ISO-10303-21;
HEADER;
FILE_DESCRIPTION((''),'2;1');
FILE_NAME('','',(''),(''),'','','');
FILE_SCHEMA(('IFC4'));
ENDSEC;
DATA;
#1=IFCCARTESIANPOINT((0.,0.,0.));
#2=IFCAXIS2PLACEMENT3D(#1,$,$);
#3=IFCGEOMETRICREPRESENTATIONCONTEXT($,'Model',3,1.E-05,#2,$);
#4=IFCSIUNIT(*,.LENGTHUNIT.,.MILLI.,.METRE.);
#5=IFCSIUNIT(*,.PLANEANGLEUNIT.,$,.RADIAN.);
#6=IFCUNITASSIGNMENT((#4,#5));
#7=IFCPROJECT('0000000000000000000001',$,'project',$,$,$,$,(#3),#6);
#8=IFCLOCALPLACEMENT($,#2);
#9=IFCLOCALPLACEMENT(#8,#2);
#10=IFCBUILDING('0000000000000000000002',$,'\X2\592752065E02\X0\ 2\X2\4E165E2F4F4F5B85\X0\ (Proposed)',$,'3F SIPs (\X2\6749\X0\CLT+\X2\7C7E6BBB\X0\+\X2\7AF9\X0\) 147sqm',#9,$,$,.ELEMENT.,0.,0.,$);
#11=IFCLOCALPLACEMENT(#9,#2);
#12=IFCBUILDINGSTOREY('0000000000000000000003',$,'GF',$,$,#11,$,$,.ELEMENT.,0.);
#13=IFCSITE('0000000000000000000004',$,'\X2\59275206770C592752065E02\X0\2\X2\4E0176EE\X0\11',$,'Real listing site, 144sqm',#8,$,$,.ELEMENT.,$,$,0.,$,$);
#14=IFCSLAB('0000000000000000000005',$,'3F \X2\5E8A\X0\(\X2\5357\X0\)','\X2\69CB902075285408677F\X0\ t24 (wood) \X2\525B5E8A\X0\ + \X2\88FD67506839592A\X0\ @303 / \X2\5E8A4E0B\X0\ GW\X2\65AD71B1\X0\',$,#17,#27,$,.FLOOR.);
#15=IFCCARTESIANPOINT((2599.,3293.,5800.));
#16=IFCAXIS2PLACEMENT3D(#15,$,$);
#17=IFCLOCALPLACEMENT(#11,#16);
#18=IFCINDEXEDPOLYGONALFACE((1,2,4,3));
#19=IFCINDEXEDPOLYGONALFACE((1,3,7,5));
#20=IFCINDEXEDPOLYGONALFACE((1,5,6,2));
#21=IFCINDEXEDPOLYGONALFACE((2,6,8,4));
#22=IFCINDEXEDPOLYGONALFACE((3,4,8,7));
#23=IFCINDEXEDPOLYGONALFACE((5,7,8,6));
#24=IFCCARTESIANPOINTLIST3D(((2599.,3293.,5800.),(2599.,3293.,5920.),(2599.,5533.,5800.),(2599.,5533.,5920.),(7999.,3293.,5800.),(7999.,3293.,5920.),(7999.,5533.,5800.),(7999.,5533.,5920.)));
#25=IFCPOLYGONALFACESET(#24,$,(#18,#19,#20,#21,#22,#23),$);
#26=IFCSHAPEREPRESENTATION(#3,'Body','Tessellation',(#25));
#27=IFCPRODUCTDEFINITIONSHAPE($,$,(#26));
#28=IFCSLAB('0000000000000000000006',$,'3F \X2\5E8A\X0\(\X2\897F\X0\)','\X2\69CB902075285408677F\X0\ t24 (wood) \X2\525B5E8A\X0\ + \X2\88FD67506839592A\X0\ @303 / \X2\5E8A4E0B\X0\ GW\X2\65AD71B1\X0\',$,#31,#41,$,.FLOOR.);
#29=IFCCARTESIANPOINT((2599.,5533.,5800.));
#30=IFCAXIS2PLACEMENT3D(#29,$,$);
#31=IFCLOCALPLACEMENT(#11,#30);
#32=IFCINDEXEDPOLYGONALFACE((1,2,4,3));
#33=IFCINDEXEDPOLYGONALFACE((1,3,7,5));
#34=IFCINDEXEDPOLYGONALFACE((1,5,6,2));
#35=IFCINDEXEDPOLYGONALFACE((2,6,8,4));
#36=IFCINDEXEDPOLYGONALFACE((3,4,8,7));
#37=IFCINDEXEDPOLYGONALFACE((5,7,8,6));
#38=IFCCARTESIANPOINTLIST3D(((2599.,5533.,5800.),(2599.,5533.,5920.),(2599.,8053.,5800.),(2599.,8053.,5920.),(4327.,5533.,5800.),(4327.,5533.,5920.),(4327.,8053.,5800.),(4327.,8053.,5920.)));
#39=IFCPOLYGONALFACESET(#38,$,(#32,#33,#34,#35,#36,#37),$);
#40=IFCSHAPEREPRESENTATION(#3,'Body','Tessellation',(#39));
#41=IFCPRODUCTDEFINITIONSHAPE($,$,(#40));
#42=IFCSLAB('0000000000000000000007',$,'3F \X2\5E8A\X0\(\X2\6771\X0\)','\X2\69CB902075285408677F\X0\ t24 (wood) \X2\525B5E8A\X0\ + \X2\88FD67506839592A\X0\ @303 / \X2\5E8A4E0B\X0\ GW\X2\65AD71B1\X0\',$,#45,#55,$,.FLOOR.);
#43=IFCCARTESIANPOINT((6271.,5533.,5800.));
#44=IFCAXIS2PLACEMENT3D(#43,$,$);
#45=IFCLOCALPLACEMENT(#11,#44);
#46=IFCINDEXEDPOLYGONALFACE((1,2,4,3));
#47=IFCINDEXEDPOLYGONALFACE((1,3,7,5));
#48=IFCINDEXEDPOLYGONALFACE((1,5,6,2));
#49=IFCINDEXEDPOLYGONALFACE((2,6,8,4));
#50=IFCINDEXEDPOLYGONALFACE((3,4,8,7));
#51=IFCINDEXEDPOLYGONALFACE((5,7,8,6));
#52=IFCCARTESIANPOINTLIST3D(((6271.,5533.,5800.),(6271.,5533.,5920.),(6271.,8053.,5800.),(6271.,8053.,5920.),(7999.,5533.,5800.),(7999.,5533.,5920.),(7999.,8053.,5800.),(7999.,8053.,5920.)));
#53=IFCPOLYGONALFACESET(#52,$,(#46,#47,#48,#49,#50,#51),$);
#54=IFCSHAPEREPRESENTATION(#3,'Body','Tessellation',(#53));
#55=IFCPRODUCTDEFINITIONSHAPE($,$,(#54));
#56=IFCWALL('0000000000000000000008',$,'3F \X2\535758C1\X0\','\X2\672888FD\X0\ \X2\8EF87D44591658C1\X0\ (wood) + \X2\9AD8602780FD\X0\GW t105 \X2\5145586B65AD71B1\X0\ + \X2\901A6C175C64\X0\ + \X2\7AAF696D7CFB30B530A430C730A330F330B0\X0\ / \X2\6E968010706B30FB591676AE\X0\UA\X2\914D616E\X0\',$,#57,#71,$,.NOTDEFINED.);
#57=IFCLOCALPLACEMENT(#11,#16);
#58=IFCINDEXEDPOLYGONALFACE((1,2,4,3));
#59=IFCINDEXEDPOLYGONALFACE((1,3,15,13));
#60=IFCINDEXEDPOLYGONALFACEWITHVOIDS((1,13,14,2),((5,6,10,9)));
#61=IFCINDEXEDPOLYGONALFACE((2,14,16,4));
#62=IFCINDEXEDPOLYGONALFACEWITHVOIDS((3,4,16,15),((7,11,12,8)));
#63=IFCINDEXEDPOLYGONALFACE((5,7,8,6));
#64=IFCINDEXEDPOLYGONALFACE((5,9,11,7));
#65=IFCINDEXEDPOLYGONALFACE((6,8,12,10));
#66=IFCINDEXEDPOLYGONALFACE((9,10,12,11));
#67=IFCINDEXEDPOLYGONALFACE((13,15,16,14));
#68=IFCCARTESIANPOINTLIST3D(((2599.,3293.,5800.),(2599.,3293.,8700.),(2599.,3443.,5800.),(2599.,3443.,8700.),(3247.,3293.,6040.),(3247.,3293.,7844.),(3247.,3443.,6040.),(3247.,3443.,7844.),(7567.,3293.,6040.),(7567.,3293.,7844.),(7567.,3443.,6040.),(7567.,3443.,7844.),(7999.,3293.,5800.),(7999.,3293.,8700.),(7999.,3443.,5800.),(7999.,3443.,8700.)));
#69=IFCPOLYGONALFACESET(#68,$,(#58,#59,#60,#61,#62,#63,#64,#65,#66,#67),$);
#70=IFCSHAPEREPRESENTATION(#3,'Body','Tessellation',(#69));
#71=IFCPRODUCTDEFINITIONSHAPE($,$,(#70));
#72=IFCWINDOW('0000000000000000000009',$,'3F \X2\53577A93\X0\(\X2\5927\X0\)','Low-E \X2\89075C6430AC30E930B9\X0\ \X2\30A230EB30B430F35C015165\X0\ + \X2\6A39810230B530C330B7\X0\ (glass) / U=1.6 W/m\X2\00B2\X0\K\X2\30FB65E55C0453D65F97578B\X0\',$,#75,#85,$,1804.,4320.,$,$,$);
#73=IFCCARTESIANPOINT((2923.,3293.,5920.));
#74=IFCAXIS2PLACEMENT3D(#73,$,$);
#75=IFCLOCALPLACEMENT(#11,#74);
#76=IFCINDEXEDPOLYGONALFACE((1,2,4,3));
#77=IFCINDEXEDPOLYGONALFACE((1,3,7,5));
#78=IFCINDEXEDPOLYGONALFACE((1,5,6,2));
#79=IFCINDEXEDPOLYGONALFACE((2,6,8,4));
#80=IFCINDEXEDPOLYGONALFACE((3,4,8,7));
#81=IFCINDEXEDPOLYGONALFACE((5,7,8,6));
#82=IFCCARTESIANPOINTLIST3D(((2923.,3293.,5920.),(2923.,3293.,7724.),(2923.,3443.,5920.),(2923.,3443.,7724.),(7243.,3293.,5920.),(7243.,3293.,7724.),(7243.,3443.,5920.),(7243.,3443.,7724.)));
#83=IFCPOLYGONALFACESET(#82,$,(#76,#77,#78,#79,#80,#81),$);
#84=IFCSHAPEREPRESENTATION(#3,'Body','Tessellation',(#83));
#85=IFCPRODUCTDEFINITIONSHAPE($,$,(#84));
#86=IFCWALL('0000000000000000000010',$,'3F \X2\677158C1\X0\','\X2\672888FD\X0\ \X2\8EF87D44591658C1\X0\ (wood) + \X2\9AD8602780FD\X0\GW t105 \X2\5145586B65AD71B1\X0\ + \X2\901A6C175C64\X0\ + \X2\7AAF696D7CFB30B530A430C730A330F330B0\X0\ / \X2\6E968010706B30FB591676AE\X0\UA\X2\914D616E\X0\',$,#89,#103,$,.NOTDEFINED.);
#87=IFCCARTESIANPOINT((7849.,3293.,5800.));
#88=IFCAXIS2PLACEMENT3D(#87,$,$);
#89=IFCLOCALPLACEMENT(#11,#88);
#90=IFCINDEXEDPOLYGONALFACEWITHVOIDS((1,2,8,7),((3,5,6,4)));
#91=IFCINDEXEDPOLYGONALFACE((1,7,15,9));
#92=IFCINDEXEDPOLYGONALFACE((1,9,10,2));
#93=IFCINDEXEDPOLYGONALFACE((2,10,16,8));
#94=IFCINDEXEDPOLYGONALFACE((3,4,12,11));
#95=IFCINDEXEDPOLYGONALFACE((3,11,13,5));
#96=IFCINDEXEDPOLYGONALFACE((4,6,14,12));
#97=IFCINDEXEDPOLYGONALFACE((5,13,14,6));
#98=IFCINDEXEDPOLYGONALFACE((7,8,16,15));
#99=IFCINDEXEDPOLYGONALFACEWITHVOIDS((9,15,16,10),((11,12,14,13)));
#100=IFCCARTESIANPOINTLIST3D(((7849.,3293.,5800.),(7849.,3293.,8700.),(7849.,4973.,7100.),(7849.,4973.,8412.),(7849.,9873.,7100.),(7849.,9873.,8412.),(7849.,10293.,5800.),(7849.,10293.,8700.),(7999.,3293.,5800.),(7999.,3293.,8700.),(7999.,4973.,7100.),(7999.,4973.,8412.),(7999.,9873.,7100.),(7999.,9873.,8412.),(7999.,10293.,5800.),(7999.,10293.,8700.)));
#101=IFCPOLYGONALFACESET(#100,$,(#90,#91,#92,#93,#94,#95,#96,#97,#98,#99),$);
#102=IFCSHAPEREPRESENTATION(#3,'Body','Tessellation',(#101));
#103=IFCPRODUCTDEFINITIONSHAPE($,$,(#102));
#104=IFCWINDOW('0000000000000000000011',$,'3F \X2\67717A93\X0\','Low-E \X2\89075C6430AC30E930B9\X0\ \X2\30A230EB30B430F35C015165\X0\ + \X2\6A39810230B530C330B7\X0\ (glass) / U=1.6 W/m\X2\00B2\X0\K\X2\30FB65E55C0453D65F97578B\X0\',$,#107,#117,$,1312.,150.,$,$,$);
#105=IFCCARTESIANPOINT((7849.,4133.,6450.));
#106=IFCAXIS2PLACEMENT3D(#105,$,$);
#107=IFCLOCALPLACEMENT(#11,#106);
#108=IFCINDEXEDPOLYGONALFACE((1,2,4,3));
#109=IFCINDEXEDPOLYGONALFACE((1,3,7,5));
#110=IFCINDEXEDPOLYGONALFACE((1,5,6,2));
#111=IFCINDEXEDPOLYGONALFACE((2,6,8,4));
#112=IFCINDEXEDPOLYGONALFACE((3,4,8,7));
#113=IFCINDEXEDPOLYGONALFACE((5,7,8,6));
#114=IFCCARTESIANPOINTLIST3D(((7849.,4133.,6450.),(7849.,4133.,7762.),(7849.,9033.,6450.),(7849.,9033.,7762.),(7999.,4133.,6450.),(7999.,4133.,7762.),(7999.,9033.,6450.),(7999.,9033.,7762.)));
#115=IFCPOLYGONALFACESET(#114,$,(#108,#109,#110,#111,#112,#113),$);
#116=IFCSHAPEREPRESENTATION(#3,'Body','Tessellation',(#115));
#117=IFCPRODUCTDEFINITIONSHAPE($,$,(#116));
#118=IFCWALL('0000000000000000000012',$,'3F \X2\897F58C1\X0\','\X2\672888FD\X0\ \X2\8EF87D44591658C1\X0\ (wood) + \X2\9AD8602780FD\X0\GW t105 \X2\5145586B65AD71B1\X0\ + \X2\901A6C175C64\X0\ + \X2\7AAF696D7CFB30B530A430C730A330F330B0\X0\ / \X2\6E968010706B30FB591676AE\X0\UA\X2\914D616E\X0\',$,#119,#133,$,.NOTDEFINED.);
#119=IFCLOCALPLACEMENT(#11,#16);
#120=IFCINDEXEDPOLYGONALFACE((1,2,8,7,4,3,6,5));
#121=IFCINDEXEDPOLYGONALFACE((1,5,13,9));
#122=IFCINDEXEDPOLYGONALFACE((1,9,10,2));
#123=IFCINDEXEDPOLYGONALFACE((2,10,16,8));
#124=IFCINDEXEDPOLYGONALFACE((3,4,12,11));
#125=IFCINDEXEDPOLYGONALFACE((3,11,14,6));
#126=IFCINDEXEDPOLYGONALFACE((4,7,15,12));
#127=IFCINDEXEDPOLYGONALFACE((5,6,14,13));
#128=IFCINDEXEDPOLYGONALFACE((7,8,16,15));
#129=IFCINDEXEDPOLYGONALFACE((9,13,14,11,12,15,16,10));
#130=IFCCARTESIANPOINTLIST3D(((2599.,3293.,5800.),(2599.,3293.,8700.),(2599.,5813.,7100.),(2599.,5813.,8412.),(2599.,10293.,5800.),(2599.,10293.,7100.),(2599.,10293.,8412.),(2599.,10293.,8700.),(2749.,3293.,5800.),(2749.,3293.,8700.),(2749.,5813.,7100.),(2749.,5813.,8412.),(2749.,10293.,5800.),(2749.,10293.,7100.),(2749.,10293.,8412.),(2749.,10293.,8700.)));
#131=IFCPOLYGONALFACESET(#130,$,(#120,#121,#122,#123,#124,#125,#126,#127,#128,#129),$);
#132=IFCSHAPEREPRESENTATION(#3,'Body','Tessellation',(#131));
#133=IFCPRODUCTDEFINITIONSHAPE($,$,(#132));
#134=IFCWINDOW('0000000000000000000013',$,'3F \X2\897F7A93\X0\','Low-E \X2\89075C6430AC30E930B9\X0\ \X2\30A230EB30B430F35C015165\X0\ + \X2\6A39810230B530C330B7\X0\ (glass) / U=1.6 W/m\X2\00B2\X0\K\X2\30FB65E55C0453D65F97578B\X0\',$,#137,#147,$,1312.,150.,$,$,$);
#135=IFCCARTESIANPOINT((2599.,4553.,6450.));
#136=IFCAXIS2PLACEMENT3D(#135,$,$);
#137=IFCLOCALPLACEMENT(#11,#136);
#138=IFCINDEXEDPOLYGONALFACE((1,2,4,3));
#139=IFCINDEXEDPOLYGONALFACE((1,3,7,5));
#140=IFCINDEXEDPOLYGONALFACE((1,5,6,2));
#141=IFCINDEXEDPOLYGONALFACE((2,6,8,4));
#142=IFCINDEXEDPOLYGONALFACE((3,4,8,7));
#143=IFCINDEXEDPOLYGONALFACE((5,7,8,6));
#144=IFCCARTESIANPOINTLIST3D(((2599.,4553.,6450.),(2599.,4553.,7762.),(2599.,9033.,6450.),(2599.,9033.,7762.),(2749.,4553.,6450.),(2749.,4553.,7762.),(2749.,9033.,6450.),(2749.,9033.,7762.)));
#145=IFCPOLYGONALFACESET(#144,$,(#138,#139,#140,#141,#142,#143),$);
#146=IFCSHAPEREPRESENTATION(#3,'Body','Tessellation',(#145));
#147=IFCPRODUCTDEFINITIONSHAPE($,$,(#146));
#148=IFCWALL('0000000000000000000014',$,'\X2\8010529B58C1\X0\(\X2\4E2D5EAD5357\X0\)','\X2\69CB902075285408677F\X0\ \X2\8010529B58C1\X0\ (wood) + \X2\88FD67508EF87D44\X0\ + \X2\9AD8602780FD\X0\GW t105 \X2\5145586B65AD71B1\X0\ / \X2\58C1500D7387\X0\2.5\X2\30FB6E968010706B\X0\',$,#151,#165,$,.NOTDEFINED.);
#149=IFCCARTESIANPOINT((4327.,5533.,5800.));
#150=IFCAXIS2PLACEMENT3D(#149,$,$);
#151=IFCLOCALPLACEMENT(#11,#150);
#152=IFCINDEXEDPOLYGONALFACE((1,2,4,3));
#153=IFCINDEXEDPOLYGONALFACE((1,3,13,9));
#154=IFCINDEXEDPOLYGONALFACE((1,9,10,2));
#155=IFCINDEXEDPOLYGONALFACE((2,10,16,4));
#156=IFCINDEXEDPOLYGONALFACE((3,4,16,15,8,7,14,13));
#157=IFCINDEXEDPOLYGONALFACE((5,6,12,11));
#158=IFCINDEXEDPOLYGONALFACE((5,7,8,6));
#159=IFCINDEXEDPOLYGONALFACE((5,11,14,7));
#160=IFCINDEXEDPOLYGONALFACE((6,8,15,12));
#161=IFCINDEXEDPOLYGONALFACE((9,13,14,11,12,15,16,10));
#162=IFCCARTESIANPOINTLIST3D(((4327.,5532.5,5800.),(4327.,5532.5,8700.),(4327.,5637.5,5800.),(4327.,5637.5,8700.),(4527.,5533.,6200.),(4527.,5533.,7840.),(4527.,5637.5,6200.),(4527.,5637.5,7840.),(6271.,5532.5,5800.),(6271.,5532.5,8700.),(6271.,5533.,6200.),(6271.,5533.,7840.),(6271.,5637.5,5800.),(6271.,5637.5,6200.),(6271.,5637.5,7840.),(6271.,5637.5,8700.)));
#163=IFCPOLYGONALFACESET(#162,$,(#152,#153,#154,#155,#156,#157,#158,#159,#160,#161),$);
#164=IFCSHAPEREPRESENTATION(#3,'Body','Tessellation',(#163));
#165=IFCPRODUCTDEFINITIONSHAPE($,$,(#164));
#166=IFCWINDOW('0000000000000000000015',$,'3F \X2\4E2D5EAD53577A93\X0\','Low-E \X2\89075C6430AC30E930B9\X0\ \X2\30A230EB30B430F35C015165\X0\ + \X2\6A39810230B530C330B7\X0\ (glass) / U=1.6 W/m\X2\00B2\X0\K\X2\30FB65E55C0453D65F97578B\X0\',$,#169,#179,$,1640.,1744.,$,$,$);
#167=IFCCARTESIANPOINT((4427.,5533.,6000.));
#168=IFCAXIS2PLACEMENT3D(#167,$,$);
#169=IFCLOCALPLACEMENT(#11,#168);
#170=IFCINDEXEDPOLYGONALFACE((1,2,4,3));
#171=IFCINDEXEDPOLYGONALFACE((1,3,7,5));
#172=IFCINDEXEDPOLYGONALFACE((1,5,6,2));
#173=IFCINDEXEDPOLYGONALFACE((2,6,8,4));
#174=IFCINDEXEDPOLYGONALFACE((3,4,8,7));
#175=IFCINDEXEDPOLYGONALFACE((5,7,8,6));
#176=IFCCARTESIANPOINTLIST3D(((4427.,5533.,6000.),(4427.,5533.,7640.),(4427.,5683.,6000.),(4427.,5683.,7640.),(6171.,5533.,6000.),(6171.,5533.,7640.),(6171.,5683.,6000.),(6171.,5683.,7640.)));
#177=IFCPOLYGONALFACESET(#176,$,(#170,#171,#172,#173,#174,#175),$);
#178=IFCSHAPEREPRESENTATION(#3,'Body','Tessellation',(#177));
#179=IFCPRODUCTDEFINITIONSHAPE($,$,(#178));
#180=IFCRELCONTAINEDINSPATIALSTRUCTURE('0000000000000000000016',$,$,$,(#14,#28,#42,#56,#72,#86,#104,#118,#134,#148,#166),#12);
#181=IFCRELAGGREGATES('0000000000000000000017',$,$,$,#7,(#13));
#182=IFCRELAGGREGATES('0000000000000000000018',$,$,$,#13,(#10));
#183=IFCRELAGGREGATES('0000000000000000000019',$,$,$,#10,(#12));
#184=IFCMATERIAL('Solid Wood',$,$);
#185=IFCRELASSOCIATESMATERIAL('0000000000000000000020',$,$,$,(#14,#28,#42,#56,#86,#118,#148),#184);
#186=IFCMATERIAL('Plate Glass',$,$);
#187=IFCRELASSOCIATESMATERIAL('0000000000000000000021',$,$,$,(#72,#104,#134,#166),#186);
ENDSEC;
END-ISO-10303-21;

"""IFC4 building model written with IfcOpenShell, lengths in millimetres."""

from ifc_helpers import new_model, si_unit, frame, frame_2d, origin, place, context, project, spatial, rectangle, extrude, material, element, fill, save


model = new_model("IFC4")

# Units and contexts
model_context = context("Model", 3, precision=1e-05, world=origin())
ifc_project = project(units=[si_unit("LENGTHUNIT", "METRE", prefix="MILLI"), si_unit("PLANEANGLEUNIT", "RADIAN")], contexts=[model_context])

# Site, building, storey
site_placement = place(None, origin())
site = spatial("IfcSite", under=ifc_project, at=site_placement, Name="大分県大分市2丁目11", ObjectType="Real listing site, 144sqm", CompositionType="ELEMENT", RefElevation=0.0)
building_placement = place(site_placement, origin())
building = spatial("IfcBuilding", under=site, at=building_placement, Name="大分市 2世帯住宅 (Proposed)", ObjectType="3F SIPs (杉CLT+籾殻+竹) 147sqm", CompositionType="ELEMENT", ElevationOfRefHeight=0.0, ElevationOfTerrain=0.0)
storey_placement = place(building_placement, origin())
storey = spatial("IfcBuildingStorey", under=building, at=storey_placement, Name="GF", CompositionType="ELEMENT", Elevation=0.0)

# Slabs
ifc_material_1 = material(Name="Solid Wood")
slab_1_placement = place(storey_placement, frame((2599.0, 3293.0, 5800.0)))
element("IfcSlab", 1, at=slab_1_placement, inside=storey, material=ifc_material_1, Name="3F 床(南)", Description="構造用合板 t24 (wood) 剛床 + 製材根太 @303 / 床下 GW断熱", PredefinedType="FLOOR", context=model_context, shape_type="SweptSolid", body=[
    extrude(rectangle(XDim=5400.0, YDim=2240.0, at=frame_2d((2700.0, 1120.0))), frame((2599.0, 3293.0, 5800.0)), (0.0, 0.0, 1.0), 120.0),
])
slab_2_placement = place(storey_placement, frame((2599.0, 5533.0, 5800.0)))
element("IfcSlab", 2, at=slab_2_placement, inside=storey, material=ifc_material_1, Name="3F 床(西)", Description="構造用合板 t24 (wood) 剛床 + 製材根太 @303 / 床下 GW断熱", PredefinedType="FLOOR", context=model_context, shape_type="SweptSolid", body=[
    extrude(rectangle(XDim=1728.0, YDim=2520.0, at=frame_2d((864.0, 1260.0))), frame((2599.0, 5533.0, 5800.0)), (0.0, 0.0, 1.0), 120.0),
])
slab_3_placement = place(storey_placement, frame((6271.0, 5533.0, 5800.0)))
element("IfcSlab", 3, at=slab_3_placement, inside=storey, material=ifc_material_1, Name="3F 床(東)", Description="構造用合板 t24 (wood) 剛床 + 製材根太 @303 / 床下 GW断熱", PredefinedType="FLOOR", context=model_context, shape_type="SweptSolid", body=[
    extrude(rectangle(XDim=1728.0, YDim=2520.0, at=frame_2d((864.0, 1260.0))), frame((6271.0, 5533.0, 5800.0)), (0.0, 0.0, 1.0), 120.0),
])

# Walls, openings, windows
wall_1_placement = place(storey_placement, frame((2599.0, 3293.0, 5800.0)))
wall_1 = element("IfcWall", 4, at=wall_1_placement, inside=storey, material=ifc_material_1, Name="3F 南壁", Description="木製 軸組外壁 (wood) + 高性能GW t105 充填断熱 + 通気層 + 窯業系サイディング / 準耐火・外皮UA配慮", PredefinedType="NOTDEFINED", context=model_context, shape_type="SweptSolid", body=[
    extrude(rectangle(XDim=5400.0, YDim=150.0, at=frame_2d((2700.0, 75.0))), frame((2599.0, 3293.0, 5800.0)), (0.0, 0.0, 1.0), 2900.0),
])
opening_1_placement = place(storey_placement, frame((2923.0, 3293.0, 5920.0)))
opening_1 = element("IfcOpeningElement", 5, at=opening_1_placement, cuts=wall_1, PredefinedType="NOTDEFINED", context=model_context, shape_type="SweptSolid", body=[
    extrude(rectangle(XDim=4320.0, YDim=150.0, at=frame_2d((2160.0, 75.0))), frame((2923.0, 3293.0, 5920.0)), (0.0, 0.0, 1.0), 1804.0),
])
ifc_material_2 = material(Name="Plate Glass")
window_1_placement = place(storey_placement, frame((2923.0, 3293.0, 5920.0)))
window_1 = element("IfcWindow", 6, at=window_1_placement, inside=storey, material=ifc_material_2, Name="3F 南窓(大)", Description="Low-E 複層ガラス アルゴン封入 + 樹脂サッシ (glass) / U=1.6 W/m²K・日射取得型", OverallHeight=1804.0, OverallWidth=4320.0, context=model_context, shape_type="SweptSolid", body=[
    extrude(rectangle(XDim=4320.0, YDim=150.0, at=frame_2d((2160.0, 75.0))), frame((2923.0, 3293.0, 5920.0)), (0.0, 0.0, 1.0), 1804.0),
])
fill(opening_1, window_1)
wall_2_placement = place(storey_placement, frame((7849.0, 3293.0, 5800.0)))
wall_2 = element("IfcWall", 7, at=wall_2_placement, inside=storey, material=ifc_material_1, Name="3F 東壁", Description="木製 軸組外壁 (wood) + 高性能GW t105 充填断熱 + 通気層 + 窯業系サイディング / 準耐火・外皮UA配慮", PredefinedType="NOTDEFINED", context=model_context, shape_type="SweptSolid", body=[
    extrude(rectangle(XDim=150.0, YDim=7000.0, at=frame_2d((75.0, 3500.0))), frame((7849.0, 3293.0, 5800.0)), (0.0, 0.0, 1.0), 2900.0),
])
opening_2_placement = place(storey_placement, frame((7849.0, 4133.0, 6450.0)))
opening_2 = element("IfcOpeningElement", 8, at=opening_2_placement, cuts=wall_2, PredefinedType="NOTDEFINED", context=model_context, shape_type="SweptSolid", body=[
    extrude(rectangle(XDim=150.0, YDim=4900.0, at=frame_2d((75.0, 2450.0))), frame((7849.0, 4133.0, 6450.0)), (0.0, 0.0, 1.0), 1312.0),
])
window_2_placement = place(storey_placement, frame((7849.0, 4133.0, 6450.0)))
window_2 = element("IfcWindow", 9, at=window_2_placement, inside=storey, material=ifc_material_2, Name="3F 東窓", Description="Low-E 複層ガラス アルゴン封入 + 樹脂サッシ (glass) / U=1.6 W/m²K・日射取得型", OverallHeight=1312.0, OverallWidth=150.0, context=model_context, shape_type="SweptSolid", body=[
    extrude(rectangle(XDim=150.0, YDim=4900.0, at=frame_2d((75.0, 2450.0))), frame((7849.0, 4133.0, 6450.0)), (0.0, 0.0, 1.0), 1312.0),
])
fill(opening_2, window_2)
wall_3_placement = place(storey_placement, frame((2599.0, 3293.0, 5800.0)))
wall_3 = element("IfcWall", 10, at=wall_3_placement, inside=storey, material=ifc_material_1, Name="3F 西壁", Description="木製 軸組外壁 (wood) + 高性能GW t105 充填断熱 + 通気層 + 窯業系サイディング / 準耐火・外皮UA配慮", PredefinedType="NOTDEFINED", context=model_context, shape_type="SweptSolid", body=[
    extrude(rectangle(XDim=150.0, YDim=7000.0, at=frame_2d((75.0, 3500.0))), frame((2599.0, 3293.0, 5800.0)), (0.0, 0.0, 1.0), 2900.0),
])
opening_3_placement = place(storey_placement, frame((2599.0, 4553.0, 6450.0)))
opening_3 = element("IfcOpeningElement", 11, at=opening_3_placement, cuts=wall_3, PredefinedType="NOTDEFINED", context=model_context, shape_type="SweptSolid", body=[
    extrude(rectangle(XDim=150.0, YDim=4480.0, at=frame_2d((75.0, 2240.0))), frame((2599.0, 4553.0, 6450.0)), (0.0, 0.0, 1.0), 1312.0),
])
window_3_placement = place(storey_placement, frame((2599.0, 4553.0, 6450.0)))
window_3 = element("IfcWindow", 12, at=window_3_placement, inside=storey, material=ifc_material_2, Name="3F 西窓", Description="Low-E 複層ガラス アルゴン封入 + 樹脂サッシ (glass) / U=1.6 W/m²K・日射取得型", OverallHeight=1312.0, OverallWidth=150.0, context=model_context, shape_type="SweptSolid", body=[
    extrude(rectangle(XDim=150.0, YDim=4480.0, at=frame_2d((75.0, 2240.0))), frame((2599.0, 4553.0, 6450.0)), (0.0, 0.0, 1.0), 1312.0),
])
fill(opening_3, window_3)
wall_4_placement = place(storey_placement, frame((4327.0, 5533.0, 5800.0)))
wall_4 = element("IfcWall", 13, at=wall_4_placement, inside=storey, material=ifc_material_1, Name="耐力壁(中庭南)", Description="構造用合板 耐力壁 (wood) + 製材軸組 + 高性能GW t105 充填断熱 / 壁倍率2.5・準耐火", PredefinedType="NOTDEFINED", context=model_context, shape_type="SweptSolid", body=[
    extrude(rectangle(XDim=1944.0, YDim=105.0, at=frame_2d((972.0, 52.0))), frame((4327.0, 5533.0, 5800.0)), (0.0, 0.0, 1.0), 2900.0),
])
opening_4_placement = place(storey_placement, frame((4427.0, 5533.0, 6000.0)))
opening_4 = element("IfcOpeningElement", 14, at=opening_4_placement, cuts=wall_4, PredefinedType="NOTDEFINED", context=model_context, shape_type="SweptSolid", body=[
    extrude(rectangle(XDim=1744.0, YDim=150.0, at=frame_2d((872.0, 75.0))), frame((4427.0, 5533.0, 6000.0)), (0.0, 0.0, 1.0), 1640.0),
])
window_4_placement = place(storey_placement, frame((4427.0, 5533.0, 6000.0)))
window_4 = element("IfcWindow", 15, at=window_4_placement, inside=storey, material=ifc_material_2, Name="3F 中庭南窓", Description="Low-E 複層ガラス アルゴン封入 + 樹脂サッシ (glass) / U=1.6 W/m²K・日射取得型", OverallHeight=1640.0, OverallWidth=1744.0, context=model_context, shape_type="SweptSolid", body=[
    extrude(rectangle(XDim=1744.0, YDim=150.0, at=frame_2d((872.0, 75.0))), frame((4427.0, 5533.0, 6000.0)), (0.0, 0.0, 1.0), 1640.0),
])
fill(opening_4, window_4)

save(model, "model.ifc")
